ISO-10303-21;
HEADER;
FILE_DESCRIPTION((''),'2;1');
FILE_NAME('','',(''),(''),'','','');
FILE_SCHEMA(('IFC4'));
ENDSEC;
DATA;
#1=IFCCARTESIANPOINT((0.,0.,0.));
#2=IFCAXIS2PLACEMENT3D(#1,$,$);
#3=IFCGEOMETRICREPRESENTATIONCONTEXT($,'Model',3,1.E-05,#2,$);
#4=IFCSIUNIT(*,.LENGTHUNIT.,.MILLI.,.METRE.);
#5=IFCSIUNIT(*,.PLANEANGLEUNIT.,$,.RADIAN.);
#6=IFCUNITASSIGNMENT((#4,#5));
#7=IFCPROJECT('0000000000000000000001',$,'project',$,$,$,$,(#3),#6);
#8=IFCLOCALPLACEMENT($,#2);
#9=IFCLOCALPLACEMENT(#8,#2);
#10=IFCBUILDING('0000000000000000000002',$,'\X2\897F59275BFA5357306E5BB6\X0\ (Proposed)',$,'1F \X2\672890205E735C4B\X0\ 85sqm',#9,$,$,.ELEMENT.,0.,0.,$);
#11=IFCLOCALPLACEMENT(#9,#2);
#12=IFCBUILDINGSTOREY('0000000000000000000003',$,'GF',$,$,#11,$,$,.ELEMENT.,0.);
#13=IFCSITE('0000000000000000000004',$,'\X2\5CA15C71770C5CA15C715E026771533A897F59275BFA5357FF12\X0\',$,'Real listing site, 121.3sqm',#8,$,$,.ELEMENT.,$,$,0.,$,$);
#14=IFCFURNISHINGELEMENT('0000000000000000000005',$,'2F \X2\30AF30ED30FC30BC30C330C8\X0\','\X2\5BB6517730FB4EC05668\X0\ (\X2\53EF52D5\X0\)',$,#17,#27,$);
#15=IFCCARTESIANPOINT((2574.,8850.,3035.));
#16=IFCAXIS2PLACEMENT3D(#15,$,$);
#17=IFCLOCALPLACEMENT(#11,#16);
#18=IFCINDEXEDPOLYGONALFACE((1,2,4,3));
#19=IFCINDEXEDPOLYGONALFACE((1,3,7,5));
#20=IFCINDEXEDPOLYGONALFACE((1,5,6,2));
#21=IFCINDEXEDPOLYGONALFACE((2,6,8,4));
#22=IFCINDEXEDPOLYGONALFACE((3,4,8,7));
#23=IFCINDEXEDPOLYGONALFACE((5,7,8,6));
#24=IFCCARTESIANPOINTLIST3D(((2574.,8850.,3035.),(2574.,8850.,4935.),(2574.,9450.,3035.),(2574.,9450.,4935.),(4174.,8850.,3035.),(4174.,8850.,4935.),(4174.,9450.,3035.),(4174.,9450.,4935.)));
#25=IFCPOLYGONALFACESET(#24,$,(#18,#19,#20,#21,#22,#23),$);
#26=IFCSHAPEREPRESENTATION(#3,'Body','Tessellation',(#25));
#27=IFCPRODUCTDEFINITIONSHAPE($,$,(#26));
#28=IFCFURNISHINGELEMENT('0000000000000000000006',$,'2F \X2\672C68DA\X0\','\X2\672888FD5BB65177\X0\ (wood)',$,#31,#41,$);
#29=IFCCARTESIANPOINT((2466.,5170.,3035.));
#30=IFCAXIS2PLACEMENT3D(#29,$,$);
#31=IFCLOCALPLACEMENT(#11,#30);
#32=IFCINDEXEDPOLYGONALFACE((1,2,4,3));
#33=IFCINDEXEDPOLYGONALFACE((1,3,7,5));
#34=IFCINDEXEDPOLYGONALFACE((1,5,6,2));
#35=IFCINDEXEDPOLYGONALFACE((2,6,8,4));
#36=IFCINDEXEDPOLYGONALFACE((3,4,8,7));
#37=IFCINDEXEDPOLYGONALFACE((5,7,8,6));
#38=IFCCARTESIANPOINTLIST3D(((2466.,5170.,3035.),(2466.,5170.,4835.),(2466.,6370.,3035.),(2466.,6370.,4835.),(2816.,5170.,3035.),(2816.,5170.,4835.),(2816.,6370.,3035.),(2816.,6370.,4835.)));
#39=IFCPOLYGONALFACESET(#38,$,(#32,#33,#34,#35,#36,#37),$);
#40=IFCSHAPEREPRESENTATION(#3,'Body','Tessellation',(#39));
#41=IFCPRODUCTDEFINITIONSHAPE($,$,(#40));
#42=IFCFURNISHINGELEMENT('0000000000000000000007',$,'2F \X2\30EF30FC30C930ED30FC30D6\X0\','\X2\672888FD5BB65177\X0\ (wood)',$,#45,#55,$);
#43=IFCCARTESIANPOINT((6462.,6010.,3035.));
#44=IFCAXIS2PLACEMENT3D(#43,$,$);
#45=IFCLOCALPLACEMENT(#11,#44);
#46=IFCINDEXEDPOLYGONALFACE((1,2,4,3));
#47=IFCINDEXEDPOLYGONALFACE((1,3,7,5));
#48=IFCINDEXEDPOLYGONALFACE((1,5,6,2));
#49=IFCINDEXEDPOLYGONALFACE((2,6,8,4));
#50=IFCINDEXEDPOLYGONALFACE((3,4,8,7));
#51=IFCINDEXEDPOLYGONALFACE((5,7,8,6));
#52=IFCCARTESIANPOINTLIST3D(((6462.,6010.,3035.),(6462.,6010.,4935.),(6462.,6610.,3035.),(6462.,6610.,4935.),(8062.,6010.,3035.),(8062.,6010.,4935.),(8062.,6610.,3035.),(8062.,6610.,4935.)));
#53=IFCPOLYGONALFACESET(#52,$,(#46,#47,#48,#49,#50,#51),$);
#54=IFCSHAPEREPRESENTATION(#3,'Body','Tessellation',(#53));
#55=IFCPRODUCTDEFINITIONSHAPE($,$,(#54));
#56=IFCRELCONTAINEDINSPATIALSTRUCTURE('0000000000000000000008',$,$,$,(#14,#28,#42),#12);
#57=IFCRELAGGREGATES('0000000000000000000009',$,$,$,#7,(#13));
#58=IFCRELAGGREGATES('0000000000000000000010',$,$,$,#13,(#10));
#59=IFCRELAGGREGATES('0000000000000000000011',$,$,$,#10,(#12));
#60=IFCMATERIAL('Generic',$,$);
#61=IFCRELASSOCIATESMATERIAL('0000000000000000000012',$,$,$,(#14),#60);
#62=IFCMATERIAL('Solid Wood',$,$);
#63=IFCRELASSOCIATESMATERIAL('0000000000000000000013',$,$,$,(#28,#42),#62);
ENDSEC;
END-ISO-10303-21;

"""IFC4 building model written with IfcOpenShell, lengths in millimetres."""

from ifc_helpers import new_model, si_unit, frame, frame_2d, origin, place, context, project, spatial, rectangle, extrude, material, element, save


model = new_model("IFC4")

# Units and contexts
model_context = context("Model", 3, precision=1e-05, world=origin())
ifc_project = project(units=[si_unit("LENGTHUNIT", "METRE", prefix="MILLI"), si_unit("PLANEANGLEUNIT", "RADIAN")], contexts=[model_context])

# Site, building, storey
site_placement = place(None, origin())
site = spatial("IfcSite", under=ifc_project, at=site_placement, Name="岡山県岡山市東区西大寺南２", ObjectType="Real listing site, 121.3sqm", CompositionType="ELEMENT", RefElevation=0.0)
building_placement = place(site_placement, origin())
building = spatial("IfcBuilding", under=site, at=building_placement, Name="西大寺南の家 (Proposed)", ObjectType="1F 木造平屋 85sqm", CompositionType="ELEMENT", ElevationOfRefHeight=0.0, ElevationOfTerrain=0.0)
storey_placement = place(building_placement, origin())
storey = spatial("IfcBuildingStorey", under=building, at=storey_placement, Name="GF", CompositionType="ELEMENT", Elevation=0.0)

# Shared definitions
ifc_material_1 = material(Name="Solid Wood")

# Shared definitions
ifc_material_2 = material(Name="Generic")

# Furnishing elements
furnishing_1_placement = place(storey_placement, frame((2574.0, 8850.0, 3035.0)))
element("IfcFurnishingElement", 1, at=furnishing_1_placement, inside=storey, material=ifc_material_2, Name="2F クローゼット", Description="家具・什器 (可動)", context=model_context, shape_type="SweptSolid", body=[
    extrude(rectangle(XDim=1600.0, YDim=600.0, at=frame_2d((800.0, 300.0))), frame((2574.0, 8850.0, 3035.0)), (0.0, 0.0, 1.0), 1900.0),
])
furnishing_2_placement = place(storey_placement, frame((2466.0, 5170.0, 3035.0)))
element("IfcFurnishingElement", 2, at=furnishing_2_placement, inside=storey, material=ifc_material_1, Name="2F 本棚", Description="木製家具 (wood)", context=model_context, shape_type="SweptSolid", body=[
    extrude(rectangle(XDim=350.0, YDim=1200.0, at=frame_2d((175.0, 600.0))), frame((2466.0, 5170.0, 3035.0)), (0.0, 0.0, 1.0), 1800.0),
])
furnishing_3_placement = place(storey_placement, frame((6462.0, 6010.0, 3035.0)))
element("IfcFurnishingElement", 3, at=furnishing_3_placement, inside=storey, material=ifc_material_1, Name="2F ワードローブ", Description="木製家具 (wood)", context=model_context, shape_type="SweptSolid", body=[
    extrude(rectangle(XDim=1600.0, YDim=600.0, at=frame_2d((800.0, 300.0))), frame((6462.0, 6010.0, 3035.0)), (0.0, 0.0, 1.0), 1900.0),
])

save(model, "model.ifc")
